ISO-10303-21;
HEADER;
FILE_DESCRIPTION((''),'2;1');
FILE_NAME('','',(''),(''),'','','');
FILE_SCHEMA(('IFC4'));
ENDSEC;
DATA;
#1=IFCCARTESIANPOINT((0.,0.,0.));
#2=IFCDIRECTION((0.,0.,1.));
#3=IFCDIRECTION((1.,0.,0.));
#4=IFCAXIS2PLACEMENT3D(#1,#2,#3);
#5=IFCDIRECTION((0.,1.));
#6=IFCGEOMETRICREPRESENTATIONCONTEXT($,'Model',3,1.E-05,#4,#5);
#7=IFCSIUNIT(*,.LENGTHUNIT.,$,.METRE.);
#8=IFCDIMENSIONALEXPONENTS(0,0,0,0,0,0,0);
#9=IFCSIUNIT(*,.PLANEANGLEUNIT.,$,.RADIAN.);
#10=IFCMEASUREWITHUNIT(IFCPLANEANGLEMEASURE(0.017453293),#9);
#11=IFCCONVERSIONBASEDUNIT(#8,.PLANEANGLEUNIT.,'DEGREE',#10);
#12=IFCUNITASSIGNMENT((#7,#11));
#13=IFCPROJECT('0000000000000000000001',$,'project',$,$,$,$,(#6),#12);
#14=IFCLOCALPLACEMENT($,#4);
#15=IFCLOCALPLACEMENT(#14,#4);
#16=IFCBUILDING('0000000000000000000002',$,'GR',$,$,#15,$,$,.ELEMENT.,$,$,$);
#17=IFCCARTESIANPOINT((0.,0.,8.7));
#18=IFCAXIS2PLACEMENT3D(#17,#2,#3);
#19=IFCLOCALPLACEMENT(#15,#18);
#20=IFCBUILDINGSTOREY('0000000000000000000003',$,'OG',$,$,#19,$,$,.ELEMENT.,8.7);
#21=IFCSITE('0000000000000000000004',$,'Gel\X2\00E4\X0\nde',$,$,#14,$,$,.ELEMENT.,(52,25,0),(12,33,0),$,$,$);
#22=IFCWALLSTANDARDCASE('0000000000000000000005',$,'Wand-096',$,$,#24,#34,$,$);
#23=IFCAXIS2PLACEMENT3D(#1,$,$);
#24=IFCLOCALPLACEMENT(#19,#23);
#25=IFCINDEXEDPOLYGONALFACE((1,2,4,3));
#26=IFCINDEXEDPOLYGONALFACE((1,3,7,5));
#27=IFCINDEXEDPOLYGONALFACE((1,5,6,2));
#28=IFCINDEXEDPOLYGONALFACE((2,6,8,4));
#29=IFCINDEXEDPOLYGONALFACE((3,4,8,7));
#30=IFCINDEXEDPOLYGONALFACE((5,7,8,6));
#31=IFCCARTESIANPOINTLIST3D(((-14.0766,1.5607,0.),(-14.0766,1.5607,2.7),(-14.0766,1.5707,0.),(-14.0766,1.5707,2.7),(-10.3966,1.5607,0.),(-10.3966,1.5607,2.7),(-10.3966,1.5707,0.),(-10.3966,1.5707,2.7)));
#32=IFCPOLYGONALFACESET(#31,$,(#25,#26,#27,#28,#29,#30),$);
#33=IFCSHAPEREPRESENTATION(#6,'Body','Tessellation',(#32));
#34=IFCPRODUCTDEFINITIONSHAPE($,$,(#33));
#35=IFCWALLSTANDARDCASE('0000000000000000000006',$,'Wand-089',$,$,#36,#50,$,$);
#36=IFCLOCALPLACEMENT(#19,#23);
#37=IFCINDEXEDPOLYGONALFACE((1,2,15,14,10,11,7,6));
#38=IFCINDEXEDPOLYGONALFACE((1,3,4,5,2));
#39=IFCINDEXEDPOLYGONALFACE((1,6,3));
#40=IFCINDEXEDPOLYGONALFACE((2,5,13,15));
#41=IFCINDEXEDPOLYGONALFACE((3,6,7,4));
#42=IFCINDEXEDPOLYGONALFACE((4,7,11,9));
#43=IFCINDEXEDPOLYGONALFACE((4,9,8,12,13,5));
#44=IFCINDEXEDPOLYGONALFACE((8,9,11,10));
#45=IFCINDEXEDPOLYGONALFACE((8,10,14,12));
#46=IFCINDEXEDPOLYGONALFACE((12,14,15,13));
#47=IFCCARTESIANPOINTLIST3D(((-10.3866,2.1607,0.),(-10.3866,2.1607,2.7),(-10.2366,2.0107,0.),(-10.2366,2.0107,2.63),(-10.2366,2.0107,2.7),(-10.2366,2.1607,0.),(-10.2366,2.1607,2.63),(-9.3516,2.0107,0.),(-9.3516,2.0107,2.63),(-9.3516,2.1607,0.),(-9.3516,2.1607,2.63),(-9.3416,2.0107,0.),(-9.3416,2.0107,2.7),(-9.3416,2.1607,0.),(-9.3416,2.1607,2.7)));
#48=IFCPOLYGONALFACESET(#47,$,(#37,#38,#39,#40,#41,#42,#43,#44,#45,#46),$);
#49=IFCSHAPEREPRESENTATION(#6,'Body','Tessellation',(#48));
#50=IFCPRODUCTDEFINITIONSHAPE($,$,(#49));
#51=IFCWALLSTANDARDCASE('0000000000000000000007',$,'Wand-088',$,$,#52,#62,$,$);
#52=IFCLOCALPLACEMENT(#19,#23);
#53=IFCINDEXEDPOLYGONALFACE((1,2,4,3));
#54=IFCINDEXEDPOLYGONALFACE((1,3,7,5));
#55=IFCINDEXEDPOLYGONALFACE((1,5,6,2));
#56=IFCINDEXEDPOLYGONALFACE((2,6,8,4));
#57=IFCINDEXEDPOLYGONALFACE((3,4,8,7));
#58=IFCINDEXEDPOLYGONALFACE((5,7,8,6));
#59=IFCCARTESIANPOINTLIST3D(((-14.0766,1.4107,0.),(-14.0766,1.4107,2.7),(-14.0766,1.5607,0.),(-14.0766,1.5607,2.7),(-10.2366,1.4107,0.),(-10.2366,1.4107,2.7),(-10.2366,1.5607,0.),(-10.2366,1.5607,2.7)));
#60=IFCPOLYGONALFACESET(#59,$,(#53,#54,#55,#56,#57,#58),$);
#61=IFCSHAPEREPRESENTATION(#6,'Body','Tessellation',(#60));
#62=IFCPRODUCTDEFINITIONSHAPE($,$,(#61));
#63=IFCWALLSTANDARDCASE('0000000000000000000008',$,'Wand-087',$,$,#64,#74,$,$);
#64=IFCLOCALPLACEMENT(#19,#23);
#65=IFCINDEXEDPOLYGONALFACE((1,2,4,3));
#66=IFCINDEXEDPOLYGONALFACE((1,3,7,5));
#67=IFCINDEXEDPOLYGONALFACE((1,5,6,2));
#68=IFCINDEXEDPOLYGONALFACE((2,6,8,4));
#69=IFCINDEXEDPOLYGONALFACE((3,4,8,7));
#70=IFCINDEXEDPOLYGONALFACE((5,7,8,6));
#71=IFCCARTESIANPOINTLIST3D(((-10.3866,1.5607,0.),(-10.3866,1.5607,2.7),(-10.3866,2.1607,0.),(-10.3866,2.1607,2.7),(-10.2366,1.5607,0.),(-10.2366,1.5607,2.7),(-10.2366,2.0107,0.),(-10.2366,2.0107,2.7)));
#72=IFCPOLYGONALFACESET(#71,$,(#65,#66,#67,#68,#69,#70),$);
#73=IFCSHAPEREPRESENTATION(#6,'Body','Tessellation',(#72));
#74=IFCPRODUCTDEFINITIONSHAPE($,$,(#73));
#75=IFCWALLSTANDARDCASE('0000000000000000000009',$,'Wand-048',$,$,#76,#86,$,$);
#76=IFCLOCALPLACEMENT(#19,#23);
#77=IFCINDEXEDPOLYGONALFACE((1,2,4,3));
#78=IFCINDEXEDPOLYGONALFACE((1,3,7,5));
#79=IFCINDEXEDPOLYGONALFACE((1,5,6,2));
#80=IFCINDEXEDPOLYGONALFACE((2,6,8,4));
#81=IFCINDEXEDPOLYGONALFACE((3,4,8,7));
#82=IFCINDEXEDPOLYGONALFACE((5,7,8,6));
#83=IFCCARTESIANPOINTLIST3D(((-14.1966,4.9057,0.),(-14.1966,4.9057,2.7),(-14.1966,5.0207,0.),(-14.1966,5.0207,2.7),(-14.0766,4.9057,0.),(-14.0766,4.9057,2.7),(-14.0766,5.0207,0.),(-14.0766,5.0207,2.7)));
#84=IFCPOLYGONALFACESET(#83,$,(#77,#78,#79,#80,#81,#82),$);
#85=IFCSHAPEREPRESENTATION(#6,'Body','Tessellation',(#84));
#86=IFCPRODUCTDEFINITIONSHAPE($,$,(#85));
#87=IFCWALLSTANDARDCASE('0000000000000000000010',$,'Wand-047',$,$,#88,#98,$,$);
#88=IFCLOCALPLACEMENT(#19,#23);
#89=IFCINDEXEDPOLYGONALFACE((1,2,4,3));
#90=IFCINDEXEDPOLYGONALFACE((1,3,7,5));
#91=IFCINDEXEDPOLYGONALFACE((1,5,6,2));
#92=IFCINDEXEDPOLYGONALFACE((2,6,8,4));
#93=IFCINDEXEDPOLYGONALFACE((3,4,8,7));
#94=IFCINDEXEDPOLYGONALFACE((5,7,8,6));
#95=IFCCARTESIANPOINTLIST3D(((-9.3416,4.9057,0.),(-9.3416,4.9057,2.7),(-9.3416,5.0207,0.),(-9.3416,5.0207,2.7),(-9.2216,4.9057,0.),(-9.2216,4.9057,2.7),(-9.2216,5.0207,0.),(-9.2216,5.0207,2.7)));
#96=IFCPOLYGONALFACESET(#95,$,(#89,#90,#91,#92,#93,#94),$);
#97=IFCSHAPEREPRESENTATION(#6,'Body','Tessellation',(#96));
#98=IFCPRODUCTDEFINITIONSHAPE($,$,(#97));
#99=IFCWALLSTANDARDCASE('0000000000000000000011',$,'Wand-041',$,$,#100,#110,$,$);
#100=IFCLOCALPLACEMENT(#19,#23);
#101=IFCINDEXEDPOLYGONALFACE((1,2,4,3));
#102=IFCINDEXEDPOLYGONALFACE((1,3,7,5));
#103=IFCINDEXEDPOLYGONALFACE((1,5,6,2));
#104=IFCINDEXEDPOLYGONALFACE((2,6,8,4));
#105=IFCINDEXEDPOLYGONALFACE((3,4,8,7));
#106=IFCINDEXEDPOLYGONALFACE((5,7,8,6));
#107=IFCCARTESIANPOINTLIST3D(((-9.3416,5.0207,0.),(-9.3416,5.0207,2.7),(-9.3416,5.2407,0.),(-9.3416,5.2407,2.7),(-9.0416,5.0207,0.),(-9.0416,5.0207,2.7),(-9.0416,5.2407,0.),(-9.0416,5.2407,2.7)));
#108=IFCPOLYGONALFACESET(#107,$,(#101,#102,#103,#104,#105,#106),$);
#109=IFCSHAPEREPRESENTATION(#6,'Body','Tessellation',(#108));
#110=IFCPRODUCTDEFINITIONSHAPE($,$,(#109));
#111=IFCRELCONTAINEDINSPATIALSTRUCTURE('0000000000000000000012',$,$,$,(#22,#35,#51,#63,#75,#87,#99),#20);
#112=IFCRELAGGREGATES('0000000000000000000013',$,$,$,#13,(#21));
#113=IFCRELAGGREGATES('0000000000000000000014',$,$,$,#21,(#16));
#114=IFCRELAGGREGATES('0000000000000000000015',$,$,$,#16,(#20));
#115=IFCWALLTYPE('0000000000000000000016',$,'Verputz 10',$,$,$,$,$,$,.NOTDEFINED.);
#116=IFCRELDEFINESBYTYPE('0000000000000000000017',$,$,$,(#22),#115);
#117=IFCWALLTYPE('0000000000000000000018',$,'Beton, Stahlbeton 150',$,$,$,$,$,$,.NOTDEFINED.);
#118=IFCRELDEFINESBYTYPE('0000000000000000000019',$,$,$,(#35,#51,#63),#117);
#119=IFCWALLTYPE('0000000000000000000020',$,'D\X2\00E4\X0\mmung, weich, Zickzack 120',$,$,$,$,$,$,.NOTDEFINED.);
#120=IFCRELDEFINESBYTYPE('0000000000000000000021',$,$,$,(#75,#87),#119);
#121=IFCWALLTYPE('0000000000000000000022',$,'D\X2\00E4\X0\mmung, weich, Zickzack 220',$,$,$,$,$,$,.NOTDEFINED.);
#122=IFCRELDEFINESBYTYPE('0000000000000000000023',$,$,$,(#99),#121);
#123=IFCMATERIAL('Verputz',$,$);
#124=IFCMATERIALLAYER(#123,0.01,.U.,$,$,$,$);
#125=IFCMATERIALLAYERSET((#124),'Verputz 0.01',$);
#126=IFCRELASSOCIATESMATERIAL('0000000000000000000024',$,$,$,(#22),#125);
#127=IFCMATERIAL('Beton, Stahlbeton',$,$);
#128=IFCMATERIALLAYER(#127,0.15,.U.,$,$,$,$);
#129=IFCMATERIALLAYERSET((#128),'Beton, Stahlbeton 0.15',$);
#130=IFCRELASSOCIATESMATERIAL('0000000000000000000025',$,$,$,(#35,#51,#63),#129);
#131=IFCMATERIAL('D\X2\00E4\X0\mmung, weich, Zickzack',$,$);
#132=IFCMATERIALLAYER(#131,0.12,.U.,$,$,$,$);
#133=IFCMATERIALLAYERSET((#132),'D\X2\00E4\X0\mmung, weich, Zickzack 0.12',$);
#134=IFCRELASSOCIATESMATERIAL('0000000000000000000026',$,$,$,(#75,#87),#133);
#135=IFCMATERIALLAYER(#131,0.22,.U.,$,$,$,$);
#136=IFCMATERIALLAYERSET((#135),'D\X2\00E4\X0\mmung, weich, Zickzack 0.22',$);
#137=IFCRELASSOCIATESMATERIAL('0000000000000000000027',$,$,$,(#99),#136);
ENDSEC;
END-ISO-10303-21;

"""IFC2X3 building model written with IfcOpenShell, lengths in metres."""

from ifc_helpers import new_model, entity, si_unit, converted_unit, direction, frame, origin_with_axes, origin_2d_with_axis, place, context, project, spatial, polyline, rectangle, outline, extrude, material, layer, layer_set, layer_usage, type_object, element, save


model = new_model("IFC2X3")

# Units and contexts
model_context = context("Model", 3, precision=1e-05, world=origin_with_axes(), true_north=direction((0.0, 1.0)))
ifc_project = project(units=[si_unit("LENGTHUNIT", "METRE"), converted_unit("PLANEANGLEUNIT", "DEGREE", entity("IfcPlaneAngleMeasure", 0.017453293), si_unit("PLANEANGLEUNIT", "RADIAN"), dimensions=[0, 0, 0, 0, 0, 0, 0])], contexts=[model_context])

# Site, building, storey
site_placement = place(None, origin_with_axes())
site = spatial("IfcSite", under=ifc_project, at=site_placement, Name="Gelände", CompositionType="ELEMENT", RefLatitude=(52, 25, 0), RefLongitude=(12, 33, 0))
building_placement = place(site_placement, origin_with_axes())
building = spatial("IfcBuilding", under=site, at=building_placement, Name="GR", CompositionType="ELEMENT")
storey_placement = place(building_placement, frame((0.0, 0.0, 8.7), z_axis=(0.0, 0.0, 1.0), x_axis=(1.0, 0.0, 0.0)))
storey = spatial("IfcBuildingStorey", under=building, at=storey_placement, Name="OG", CompositionType="ELEMENT", Elevation=8.7)

# Wall
ifc_material_1 = material(Name="Dämmung, weich, Zickzack")
ifc_material_2 = material(Name="Beton, Stahlbeton")
ifc_material_3 = material(Name="Verputz")
ifc_layer_1 = layer(ifc_material_3, 0.01, ventilated="UNKNOWN")
ifc_layer_set_1 = layer_set([ifc_layer_1], Name="Verputz 0.01")
wall_type_1 = type_object("IfcWallType", Name="Verputz 10", PredefinedType="NOTDEFINED")
ifc_layer_usage_1 = layer_usage(ifc_layer_set_1, "AXIS2", "POSITIVE", 0.0)
wall_1_placement = place(storey_placement, frame((-14.0766, 1.5607, 0.0), z_axis=(0.0, 0.0, 1.0), x_axis=(1.0, 0.0, 0.0)))
element("IfcWallStandardCase", 1, at=wall_1_placement, inside=storey, type_object=wall_type_1, material=ifc_layer_usage_1, Name="Wand-096", context=model_context, shape_type="SweptSolid", body=[
    extrude(outline(polyline([(0.0, 0.0), (3.68, 0.0), (3.68, 0.01), (0.0, 0.01), (0.0, 0.0)])), origin_with_axes(), (0.0, 0.0, 1.0), 2.7),
])

# Wall, opening
ifc_layer_2 = layer(ifc_material_2, 0.15, ventilated="UNKNOWN")
ifc_layer_set_2 = layer_set([ifc_layer_2], Name="Beton, Stahlbeton 0.15")
ifc_layer_usage_2 = layer_usage(ifc_layer_set_2, "AXIS2", "NEGATIVE", 0.0)
wall_type_2 = type_object("IfcWallType", Name="Beton, Stahlbeton 150", PredefinedType="NOTDEFINED")
wall_2_placement = place(storey_placement, frame((-10.2366, 2.1607, 0.0), z_axis=(0.0, 0.0, 1.0), x_axis=(1.0, 0.0, 0.0)))
wall_2 = element("IfcWallStandardCase", 2, at=wall_2_placement, inside=storey, type_object=wall_type_2, material=ifc_layer_usage_2, Name="Wand-089", context=model_context, shape_type="SweptSolid", body=[
    extrude(outline(polyline([(0.0, -0.15), (0.895, -0.15), (0.895, 0.0), (-0.15, 0.0), (0.0, -0.15)])), origin_with_axes(), (0.0, 0.0, 1.0), 2.7),
])
opening_1_placement = place(wall_2_placement, frame((0.4425, 0.0, 0.0), z_axis=(0.0, 0.0, 1.0), x_axis=(1.0, 0.0, 0.0)))
element("IfcOpeningElement", 3, at=opening_1_placement, cuts=wall_2, context=model_context, shape_type="SweptSolid", body=[
    extrude(rectangle(XDim=0.885, YDim=2.63, at=origin_2d_with_axis()), frame((0.0, -0.151, 1.315), z_axis=(0.0, 1.0, 0.0), x_axis=(1.0, 0.0, 0.0)), (0.0, 0.0, 1.0), 0.452),
])

# Wall
ifc_layer_usage_3 = layer_usage(ifc_layer_set_2, "AXIS2", "POSITIVE", 0.0)
wall_3_placement = place(storey_placement, frame((-10.2366, 1.5607, 0.0), z_axis=(0.0, 0.0, 1.0), x_axis=(-1.0, 0.0, 0.0)))
element("IfcWallStandardCase", 4, at=wall_3_placement, inside=storey, type_object=wall_type_2, material=ifc_layer_usage_3, Name="Wand-088", context=model_context, shape_type="SweptSolid", body=[
    extrude(outline(polyline([(0.0, 0.0), (3.84, 0.0), (3.84, 0.15), (0.0, 0.15), (0.0, 0.0)])), origin_with_axes(), (0.0, 0.0, 1.0), 2.7),
])

# Walls
ifc_layer_usage_4 = layer_usage(ifc_layer_set_2, "AXIS2", "NEGATIVE", 0.0)
wall_4_placement = place(storey_placement, frame((-10.2366, 2.1607, 0.0), z_axis=(0.0, 0.0, 1.0), x_axis=(0.0, -1.0, 0.0)))
element("IfcWallStandardCase", 5, at=wall_4_placement, inside=storey, type_object=wall_type_2, material=ifc_layer_usage_4, Name="Wand-087", context=model_context, shape_type="SweptSolid", body=[
    extrude(outline(polyline([(0.0, -0.15), (0.6, -0.15), (0.6, 0.0), (0.15, 0.0), (0.0, -0.15)])), origin_with_axes(), (0.0, 0.0, 1.0), 2.7),
])
ifc_layer_3 = layer(ifc_material_1, 0.12, ventilated="UNKNOWN")
ifc_layer_set_3 = layer_set([ifc_layer_3], Name="Dämmung, weich, Zickzack 0.12")
ifc_layer_usage_5 = layer_usage(ifc_layer_set_3, "AXIS2", "POSITIVE", 0.0)
wall_type_3 = type_object("IfcWallType", Name="Dämmung, weich, Zickzack 120", PredefinedType="NOTDEFINED")
wall_5_placement = place(storey_placement, frame((-14.0766, 4.9057, 0.0), z_axis=(0.0, 0.0, 1.0), x_axis=(0.0, 1.0, 0.0)))
element("IfcWallStandardCase", 6, at=wall_5_placement, inside=storey, type_object=wall_type_3, material=ifc_layer_usage_5, Name="Wand-048", context=model_context, shape_type="SweptSolid", body=[
    extrude(outline(polyline([(0.0, 0.0), (0.115, 0.0), (0.115, 0.12), (0.0, 0.12), (0.0, 0.0)])), origin_with_axes(), (0.0, 0.0, 1.0), 2.7),
])
ifc_layer_usage_6 = layer_usage(ifc_layer_set_3, "AXIS2", "POSITIVE", 0.0)
wall_6_placement = place(storey_placement, frame((-9.3416, 5.0207, 0.0), z_axis=(0.0, 0.0, 1.0), x_axis=(0.0, -1.0, 0.0)))
element("IfcWallStandardCase", 7, at=wall_6_placement, inside=storey, type_object=wall_type_3, material=ifc_layer_usage_6, Name="Wand-047", context=model_context, shape_type="SweptSolid", body=[
    extrude(outline(polyline([(0.0, 0.0), (0.115, 0.0), (0.115, 0.12), (0.0, 0.12), (0.0, 0.0)])), origin_with_axes(), (0.0, 0.0, 1.0), 2.7),
])
ifc_layer_4 = layer(ifc_material_1, 0.22, ventilated="UNKNOWN")
ifc_layer_set_4 = layer_set([ifc_layer_4], Name="Dämmung, weich, Zickzack 0.22")
ifc_layer_usage_7 = layer_usage(ifc_layer_set_4, "AXIS2", "POSITIVE", 0.0)
wall_type_4 = type_object("IfcWallType", Name="Dämmung, weich, Zickzack 220", PredefinedType="NOTDEFINED")
wall_7_placement = place(storey_placement, frame((-9.3416, 5.0207, 0.0), z_axis=(0.0, 0.0, 1.0), x_axis=(1.0, 0.0, 0.0)))
element("IfcWallStandardCase", 8, at=wall_7_placement, inside=storey, type_object=wall_type_4, material=ifc_layer_usage_7, Name="Wand-041", context=model_context, shape_type="SweptSolid", body=[
    extrude(outline(polyline([(0.0, 0.0), (0.3, 0.0), (0.3, 0.22), (0.0, 0.22), (0.0, 0.0)])), origin_with_axes(), (0.0, 0.0, 1.0), 2.7),
])

save(model, "model.ifc")
